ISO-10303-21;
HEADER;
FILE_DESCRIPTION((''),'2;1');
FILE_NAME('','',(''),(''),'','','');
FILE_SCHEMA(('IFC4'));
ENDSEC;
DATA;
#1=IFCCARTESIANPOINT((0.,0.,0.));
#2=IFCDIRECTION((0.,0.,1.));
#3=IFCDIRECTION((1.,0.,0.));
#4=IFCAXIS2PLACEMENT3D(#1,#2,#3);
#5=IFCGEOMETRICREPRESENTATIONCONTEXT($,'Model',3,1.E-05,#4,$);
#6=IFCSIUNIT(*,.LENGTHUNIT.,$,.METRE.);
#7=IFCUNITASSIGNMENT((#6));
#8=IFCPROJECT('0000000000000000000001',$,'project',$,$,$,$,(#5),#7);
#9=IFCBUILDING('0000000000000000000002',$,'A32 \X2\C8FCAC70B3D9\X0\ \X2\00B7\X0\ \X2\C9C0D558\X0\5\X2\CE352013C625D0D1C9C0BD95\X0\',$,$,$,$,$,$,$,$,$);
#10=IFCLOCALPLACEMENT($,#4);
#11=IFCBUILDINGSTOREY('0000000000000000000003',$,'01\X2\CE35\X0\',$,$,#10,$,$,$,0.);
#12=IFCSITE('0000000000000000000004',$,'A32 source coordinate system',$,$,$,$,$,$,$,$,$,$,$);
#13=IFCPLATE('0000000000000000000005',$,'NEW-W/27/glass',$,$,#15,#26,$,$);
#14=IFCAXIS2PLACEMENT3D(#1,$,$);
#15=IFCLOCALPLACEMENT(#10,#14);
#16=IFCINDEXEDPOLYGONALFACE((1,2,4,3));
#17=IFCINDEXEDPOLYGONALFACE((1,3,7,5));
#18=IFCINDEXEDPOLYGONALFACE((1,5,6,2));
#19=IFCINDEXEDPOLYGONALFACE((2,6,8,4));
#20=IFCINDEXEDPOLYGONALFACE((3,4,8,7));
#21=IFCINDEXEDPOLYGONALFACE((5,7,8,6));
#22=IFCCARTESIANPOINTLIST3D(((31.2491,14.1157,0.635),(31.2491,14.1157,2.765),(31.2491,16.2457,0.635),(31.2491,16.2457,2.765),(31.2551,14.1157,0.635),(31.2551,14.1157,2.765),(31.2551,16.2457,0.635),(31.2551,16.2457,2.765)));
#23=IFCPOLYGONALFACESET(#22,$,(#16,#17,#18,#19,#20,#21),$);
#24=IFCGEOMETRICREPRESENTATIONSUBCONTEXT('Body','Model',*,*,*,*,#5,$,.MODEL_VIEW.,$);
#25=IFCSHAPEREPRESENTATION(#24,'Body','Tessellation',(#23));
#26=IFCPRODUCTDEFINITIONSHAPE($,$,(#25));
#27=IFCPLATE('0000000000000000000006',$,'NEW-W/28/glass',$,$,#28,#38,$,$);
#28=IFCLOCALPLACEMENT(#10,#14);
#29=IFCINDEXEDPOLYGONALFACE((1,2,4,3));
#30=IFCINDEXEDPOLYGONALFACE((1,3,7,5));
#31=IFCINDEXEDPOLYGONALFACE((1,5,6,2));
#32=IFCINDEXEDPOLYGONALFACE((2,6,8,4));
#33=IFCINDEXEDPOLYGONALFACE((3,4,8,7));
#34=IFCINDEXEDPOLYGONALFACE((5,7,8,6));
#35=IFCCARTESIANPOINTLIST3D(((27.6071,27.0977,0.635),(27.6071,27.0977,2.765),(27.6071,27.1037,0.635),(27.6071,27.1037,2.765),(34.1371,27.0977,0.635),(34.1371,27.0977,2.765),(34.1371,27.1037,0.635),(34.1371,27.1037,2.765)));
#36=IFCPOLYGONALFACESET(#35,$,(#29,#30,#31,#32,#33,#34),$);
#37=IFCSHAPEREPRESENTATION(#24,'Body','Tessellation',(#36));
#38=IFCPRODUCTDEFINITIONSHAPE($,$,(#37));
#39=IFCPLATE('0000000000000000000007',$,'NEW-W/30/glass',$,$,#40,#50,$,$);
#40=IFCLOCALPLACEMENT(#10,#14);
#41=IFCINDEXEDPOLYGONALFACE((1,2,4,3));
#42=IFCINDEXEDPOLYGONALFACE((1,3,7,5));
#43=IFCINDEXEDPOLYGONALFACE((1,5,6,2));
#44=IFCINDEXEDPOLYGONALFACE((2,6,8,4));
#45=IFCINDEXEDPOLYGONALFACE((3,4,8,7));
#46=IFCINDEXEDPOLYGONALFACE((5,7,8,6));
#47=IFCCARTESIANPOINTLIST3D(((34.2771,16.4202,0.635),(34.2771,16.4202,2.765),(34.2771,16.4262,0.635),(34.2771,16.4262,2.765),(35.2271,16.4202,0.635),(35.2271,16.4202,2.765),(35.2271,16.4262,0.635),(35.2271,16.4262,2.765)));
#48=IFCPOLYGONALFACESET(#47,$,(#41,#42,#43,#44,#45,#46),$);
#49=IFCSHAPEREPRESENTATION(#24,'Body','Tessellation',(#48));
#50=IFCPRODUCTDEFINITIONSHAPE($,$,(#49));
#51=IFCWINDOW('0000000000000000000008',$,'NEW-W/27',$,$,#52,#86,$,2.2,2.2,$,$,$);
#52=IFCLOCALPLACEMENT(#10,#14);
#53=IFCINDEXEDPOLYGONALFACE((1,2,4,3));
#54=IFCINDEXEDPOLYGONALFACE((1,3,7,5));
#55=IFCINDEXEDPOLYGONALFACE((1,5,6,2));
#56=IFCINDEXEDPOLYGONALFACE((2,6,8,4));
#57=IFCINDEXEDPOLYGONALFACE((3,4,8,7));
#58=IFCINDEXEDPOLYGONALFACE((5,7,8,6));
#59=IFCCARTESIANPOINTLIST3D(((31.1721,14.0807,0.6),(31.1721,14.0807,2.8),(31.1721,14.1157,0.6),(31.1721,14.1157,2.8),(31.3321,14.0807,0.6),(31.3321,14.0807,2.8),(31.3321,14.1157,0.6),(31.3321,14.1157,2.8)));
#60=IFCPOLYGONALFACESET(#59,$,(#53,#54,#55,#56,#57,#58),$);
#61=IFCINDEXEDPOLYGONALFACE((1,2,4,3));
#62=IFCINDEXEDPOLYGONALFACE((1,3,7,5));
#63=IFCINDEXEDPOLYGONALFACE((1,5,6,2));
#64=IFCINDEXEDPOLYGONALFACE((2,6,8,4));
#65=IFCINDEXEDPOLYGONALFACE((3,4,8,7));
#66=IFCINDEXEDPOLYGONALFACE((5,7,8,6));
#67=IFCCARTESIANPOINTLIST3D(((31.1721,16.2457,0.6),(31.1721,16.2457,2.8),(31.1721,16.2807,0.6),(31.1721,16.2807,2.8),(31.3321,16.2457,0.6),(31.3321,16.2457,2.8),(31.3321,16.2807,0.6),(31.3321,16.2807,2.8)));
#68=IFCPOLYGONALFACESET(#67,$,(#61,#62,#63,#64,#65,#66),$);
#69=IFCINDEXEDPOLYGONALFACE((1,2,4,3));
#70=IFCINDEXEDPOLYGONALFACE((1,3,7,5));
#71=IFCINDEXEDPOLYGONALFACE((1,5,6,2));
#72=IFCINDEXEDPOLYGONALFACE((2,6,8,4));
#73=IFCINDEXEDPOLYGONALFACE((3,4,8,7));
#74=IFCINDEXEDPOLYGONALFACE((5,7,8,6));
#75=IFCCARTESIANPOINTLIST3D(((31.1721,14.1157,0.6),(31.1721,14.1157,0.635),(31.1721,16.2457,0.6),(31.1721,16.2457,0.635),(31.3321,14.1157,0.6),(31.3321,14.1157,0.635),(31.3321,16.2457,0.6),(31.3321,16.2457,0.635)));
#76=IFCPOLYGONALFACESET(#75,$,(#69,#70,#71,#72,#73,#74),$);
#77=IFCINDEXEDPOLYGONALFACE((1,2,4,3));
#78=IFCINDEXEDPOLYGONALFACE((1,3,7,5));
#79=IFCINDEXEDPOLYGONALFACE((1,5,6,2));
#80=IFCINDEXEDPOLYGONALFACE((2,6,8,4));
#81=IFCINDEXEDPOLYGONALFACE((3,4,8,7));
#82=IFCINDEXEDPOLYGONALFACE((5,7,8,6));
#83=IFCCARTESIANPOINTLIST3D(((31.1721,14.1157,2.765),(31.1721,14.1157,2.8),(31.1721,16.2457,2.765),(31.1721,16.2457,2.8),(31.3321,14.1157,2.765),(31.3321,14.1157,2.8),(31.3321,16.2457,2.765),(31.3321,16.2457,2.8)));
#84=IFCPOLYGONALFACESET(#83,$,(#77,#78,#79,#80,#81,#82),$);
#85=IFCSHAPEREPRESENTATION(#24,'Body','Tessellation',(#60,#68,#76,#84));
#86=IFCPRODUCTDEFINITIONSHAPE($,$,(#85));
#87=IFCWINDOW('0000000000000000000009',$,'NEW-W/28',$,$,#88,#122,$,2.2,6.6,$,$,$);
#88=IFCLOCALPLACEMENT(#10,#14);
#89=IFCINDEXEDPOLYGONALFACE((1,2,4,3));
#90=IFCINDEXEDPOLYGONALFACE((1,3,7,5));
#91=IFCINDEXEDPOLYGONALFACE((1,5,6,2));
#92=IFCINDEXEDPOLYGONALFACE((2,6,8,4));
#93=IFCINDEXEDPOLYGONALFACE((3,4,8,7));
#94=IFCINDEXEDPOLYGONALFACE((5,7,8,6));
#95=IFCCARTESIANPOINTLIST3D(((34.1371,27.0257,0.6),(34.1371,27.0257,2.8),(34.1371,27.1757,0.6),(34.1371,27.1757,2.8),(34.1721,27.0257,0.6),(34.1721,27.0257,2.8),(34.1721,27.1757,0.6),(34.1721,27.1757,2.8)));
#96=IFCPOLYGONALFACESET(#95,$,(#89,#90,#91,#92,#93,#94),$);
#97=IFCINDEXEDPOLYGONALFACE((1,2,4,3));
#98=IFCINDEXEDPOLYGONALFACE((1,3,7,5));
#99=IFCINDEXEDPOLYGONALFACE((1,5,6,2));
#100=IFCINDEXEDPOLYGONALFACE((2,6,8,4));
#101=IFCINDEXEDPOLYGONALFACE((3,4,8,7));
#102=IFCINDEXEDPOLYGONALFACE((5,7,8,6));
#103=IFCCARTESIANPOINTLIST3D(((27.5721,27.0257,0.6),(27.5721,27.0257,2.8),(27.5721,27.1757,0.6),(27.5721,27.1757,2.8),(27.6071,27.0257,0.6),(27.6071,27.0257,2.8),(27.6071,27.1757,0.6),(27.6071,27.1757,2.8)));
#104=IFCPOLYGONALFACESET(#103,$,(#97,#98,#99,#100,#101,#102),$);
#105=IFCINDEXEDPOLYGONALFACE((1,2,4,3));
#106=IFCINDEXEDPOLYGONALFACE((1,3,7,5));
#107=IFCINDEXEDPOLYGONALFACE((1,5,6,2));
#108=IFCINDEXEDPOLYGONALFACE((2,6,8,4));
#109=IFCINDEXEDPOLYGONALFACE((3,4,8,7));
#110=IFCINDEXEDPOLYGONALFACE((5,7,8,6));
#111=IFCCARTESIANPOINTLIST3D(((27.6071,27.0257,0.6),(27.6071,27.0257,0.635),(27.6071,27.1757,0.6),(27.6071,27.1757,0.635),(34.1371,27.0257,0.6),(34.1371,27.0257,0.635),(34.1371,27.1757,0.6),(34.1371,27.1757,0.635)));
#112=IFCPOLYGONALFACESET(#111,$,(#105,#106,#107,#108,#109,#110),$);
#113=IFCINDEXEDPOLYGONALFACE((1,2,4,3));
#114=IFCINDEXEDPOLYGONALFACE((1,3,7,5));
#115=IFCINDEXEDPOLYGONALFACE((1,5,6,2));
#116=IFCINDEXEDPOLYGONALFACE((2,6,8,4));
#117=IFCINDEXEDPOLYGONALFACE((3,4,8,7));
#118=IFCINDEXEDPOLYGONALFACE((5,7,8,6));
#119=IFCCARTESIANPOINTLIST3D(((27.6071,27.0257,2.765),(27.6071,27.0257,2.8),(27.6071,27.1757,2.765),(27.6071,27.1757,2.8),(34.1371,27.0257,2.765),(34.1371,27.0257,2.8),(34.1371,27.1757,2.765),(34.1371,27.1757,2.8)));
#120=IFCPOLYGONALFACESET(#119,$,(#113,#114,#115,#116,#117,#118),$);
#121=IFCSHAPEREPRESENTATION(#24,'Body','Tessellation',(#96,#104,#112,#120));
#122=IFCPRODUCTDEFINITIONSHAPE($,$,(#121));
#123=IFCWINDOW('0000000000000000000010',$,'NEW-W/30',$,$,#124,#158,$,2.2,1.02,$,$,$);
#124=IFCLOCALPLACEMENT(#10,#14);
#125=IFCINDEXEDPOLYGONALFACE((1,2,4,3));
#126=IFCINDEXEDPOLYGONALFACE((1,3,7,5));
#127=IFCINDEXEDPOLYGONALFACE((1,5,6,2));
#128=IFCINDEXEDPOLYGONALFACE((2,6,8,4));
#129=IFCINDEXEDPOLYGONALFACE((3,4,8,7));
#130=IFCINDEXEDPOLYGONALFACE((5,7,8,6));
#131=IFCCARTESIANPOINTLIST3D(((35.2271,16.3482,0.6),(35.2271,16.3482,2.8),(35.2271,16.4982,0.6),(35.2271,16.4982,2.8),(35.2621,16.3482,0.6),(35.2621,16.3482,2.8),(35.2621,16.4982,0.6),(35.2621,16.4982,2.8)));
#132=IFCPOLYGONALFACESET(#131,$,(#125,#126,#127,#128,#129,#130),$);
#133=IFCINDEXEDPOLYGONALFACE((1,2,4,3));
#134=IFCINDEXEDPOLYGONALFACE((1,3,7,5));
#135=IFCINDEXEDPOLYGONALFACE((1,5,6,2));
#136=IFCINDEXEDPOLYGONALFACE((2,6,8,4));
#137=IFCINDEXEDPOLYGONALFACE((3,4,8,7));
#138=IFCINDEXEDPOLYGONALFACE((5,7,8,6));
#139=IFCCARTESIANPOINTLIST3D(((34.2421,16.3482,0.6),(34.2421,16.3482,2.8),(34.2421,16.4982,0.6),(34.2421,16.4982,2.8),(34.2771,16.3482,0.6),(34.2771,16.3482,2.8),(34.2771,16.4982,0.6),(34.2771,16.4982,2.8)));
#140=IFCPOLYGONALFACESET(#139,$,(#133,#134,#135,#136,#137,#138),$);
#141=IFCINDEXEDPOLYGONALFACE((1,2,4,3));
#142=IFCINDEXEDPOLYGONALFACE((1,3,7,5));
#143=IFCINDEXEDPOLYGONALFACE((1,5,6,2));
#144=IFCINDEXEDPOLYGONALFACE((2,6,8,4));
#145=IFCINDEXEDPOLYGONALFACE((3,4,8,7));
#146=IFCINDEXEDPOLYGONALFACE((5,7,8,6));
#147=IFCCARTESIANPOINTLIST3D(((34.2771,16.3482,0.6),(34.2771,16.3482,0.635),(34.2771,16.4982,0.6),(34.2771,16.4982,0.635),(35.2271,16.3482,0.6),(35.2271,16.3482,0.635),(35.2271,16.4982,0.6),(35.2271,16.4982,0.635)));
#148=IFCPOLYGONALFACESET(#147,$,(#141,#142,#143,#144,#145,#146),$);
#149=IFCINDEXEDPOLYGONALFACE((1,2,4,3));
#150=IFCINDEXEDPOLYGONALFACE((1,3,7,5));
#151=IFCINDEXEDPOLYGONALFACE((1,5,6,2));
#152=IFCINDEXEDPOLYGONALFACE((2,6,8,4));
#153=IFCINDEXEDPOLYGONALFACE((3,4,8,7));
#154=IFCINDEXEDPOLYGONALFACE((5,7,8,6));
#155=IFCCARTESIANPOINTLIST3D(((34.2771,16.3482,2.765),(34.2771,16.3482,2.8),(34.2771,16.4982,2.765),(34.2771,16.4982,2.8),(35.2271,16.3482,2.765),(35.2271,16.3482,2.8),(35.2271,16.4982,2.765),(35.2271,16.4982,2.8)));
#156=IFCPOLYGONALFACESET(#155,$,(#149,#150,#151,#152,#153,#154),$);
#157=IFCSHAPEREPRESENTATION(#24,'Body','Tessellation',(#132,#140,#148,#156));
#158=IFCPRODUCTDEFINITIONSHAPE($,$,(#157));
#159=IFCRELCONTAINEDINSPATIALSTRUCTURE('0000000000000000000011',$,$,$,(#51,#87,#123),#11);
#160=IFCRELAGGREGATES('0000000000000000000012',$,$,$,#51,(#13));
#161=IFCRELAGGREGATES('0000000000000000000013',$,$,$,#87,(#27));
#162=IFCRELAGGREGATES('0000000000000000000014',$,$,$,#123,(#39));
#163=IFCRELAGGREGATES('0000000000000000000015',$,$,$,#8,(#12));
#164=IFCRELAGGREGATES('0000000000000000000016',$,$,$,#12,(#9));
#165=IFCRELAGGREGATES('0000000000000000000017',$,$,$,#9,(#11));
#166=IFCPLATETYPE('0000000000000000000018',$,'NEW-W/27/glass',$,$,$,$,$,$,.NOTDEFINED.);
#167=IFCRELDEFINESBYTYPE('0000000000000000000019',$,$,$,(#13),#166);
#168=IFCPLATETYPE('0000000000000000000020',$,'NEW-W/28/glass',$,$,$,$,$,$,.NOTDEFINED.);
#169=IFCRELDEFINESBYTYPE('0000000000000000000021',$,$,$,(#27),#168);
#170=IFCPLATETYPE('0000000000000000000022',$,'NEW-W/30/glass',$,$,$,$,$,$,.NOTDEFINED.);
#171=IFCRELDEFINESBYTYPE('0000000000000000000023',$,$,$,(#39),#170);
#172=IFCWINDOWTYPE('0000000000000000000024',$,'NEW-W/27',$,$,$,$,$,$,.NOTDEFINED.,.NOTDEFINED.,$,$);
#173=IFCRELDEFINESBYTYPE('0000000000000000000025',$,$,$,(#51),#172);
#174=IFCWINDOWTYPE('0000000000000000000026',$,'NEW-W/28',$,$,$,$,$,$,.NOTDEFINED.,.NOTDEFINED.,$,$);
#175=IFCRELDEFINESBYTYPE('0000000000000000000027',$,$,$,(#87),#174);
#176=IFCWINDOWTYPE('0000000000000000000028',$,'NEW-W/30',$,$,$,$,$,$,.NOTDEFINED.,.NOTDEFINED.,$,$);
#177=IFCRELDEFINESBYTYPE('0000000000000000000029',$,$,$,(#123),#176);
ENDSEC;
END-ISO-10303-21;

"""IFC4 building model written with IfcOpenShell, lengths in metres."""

from ifc_helpers import new_model, si_unit, frame, origin, origin_with_axes, place, context, subcontext, project, spatial, polyline, outline, extrude, source, transform, mapped, type_object, type_shapes, element, aggregate, save


model = new_model("IFC4")

# Units and contexts
model_context = context("Model", 3, precision=1e-05, world=origin_with_axes())
body_context = subcontext(model_context, "Body", "Model", "MODEL_VIEW")
ifc_project = project(units=[si_unit("LENGTHUNIT", "METRE")], contexts=[model_context])

# Plates
storey_placement = place(None, origin_with_axes())
plate_type_1 = type_object("IfcPlateType", Name="NEW-W/27/glass", PredefinedType="NOTDEFINED")
shared_shape_1 = source(origin(), body_context, "Body", "SweptSolid", [
    extrude(outline(polyline([(31.2551, 14.1157), (31.2491, 14.1157), (31.2491, 16.2457), (31.2551, 16.2457), (31.2551, 14.1157)])), frame((0.0, 0.0, 0.635)), (0.0, 0.0, 1.0), 2.13),
])
type_shapes(plate_type_1, [shared_shape_1])
window_1_placement = place(storey_placement, origin_with_axes())
plate_1_placement = place(window_1_placement, origin_with_axes())
plate_1 = element("IfcPlate", 1, at=plate_1_placement, type_object=plate_type_1, Name="NEW-W/27/glass", context=body_context, shape_type="MappedRepresentation", body=[
    mapped(shared_shape_1, transform((0.0, 0.0, 0.0), scale=1.0)),
])
plate_type_2 = type_object("IfcPlateType", Name="NEW-W/28/glass", PredefinedType="NOTDEFINED")
shared_shape_2 = source(origin(), body_context, "Body", "SweptSolid", [
    extrude(outline(polyline([(34.1371, 27.0977), (27.6071, 27.0977), (27.6071, 27.1037), (34.1371, 27.1037), (34.1371, 27.0977)])), frame((0.0, 0.0, 0.635)), (0.0, 0.0, 1.0), 2.13),
])
type_shapes(plate_type_2, [shared_shape_2])
window_2_placement = place(storey_placement, origin_with_axes())
plate_2_placement = place(window_2_placement, origin_with_axes())
plate_2 = element("IfcPlate", 2, at=plate_2_placement, type_object=plate_type_2, Name="NEW-W/28/glass", context=body_context, shape_type="MappedRepresentation", body=[
    mapped(shared_shape_2, transform((0.0, 0.0, 0.0), scale=1.0)),
])
plate_type_3 = type_object("IfcPlateType", Name="NEW-W/30/glass", PredefinedType="NOTDEFINED")
shared_shape_3 = source(origin(), body_context, "Body", "SweptSolid", [
    extrude(outline(polyline([(35.2271, 16.4202), (34.2771, 16.4202), (34.2771, 16.4262), (35.2271, 16.4262), (35.2271, 16.4202)])), frame((0.0, 0.0, 0.635)), (0.0, 0.0, 1.0), 2.13),
])
type_shapes(plate_type_3, [shared_shape_3])
window_3_placement = place(storey_placement, origin_with_axes())
plate_3_placement = place(window_3_placement, origin_with_axes())
plate_3 = element("IfcPlate", 3, at=plate_3_placement, type_object=plate_type_3, Name="NEW-W/30/glass", context=body_context, shape_type="MappedRepresentation", body=[
    mapped(shared_shape_3, transform((0.0, 0.0, 0.0), scale=1.0)),
])

# Site, building, storey
site = spatial("IfcSite", under=ifc_project, Name="A32 source coordinate system")
building = spatial("IfcBuilding", under=site, Name="A32 주거동 · 지하5층–옥탑지붕")
storey = spatial("IfcBuildingStorey", under=building, at=storey_placement, Name="01층", Elevation=0.0)

# Windows
window_type_1 = type_object("IfcWindowType", Name="NEW-W/27", PartitioningType="NOTDEFINED", PredefinedType="NOTDEFINED")
shared_shape_4 = source(origin(), body_context, "Body", "SweptSolid", [
    extrude(outline(polyline([(31.1721, 14.0807), (31.1721, 14.1157), (31.3321, 14.1157), (31.3321, 14.0807), (31.1721, 14.0807)])), frame((0.0, 0.0, 0.6)), (0.0, 0.0, 1.0), 2.2),
    extrude(outline(polyline([(31.1721, 16.2457), (31.1721, 16.2807), (31.3321, 16.2807), (31.3321, 16.2457), (31.1721, 16.2457)])), frame((0.0, 0.0, 0.6)), (0.0, 0.0, 1.0), 2.2),
    extrude(outline(polyline([(31.3321, 14.1157), (31.3321, 16.2457), (31.1721, 16.2457), (31.1721, 14.1157), (31.3321, 14.1157)])), frame((0.0, 0.0, 0.6)), (0.0, 0.0, 1.0), 0.035),
    extrude(outline(polyline([(31.3321, 14.1157), (31.3321, 16.2457), (31.1721, 16.2457), (31.1721, 14.1157), (31.3321, 14.1157)])), frame((0.0, 0.0, 2.765)), (0.0, 0.0, 1.0), 0.035),
])
type_shapes(window_type_1, [shared_shape_4])
window_1 = element("IfcWindow", 4, at=window_1_placement, inside=storey, type_object=window_type_1, Name="NEW-W/27", OverallHeight=2.2, OverallWidth=2.2, context=body_context, shape_type="MappedRepresentation", body=[
    mapped(shared_shape_4, transform((0.0, 0.0, 0.0), scale=1.0)),
])
aggregate(window_1, [plate_1])
window_type_2 = type_object("IfcWindowType", Name="NEW-W/28", PartitioningType="NOTDEFINED", PredefinedType="NOTDEFINED")
shared_shape_5 = source(origin(), body_context, "Body", "SweptSolid", [
    extrude(outline(polyline([(34.1371, 27.0257), (34.1371, 27.1757), (34.1721, 27.1757), (34.1721, 27.0257), (34.1371, 27.0257)])), frame((0.0, 0.0, 0.6)), (0.0, 0.0, 1.0), 2.2),
    extrude(outline(polyline([(27.5721, 27.0257), (27.5721, 27.1757), (27.6071, 27.1757), (27.6071, 27.0257), (27.5721, 27.0257)])), frame((0.0, 0.0, 0.6)), (0.0, 0.0, 1.0), 2.2),
    extrude(outline(polyline([(34.1371, 27.0257), (34.1371, 27.1757), (27.6071, 27.1757), (27.6071, 27.0257), (34.1371, 27.0257)])), frame((0.0, 0.0, 0.6)), (0.0, 0.0, 1.0), 0.035),
    extrude(outline(polyline([(34.1371, 27.0257), (34.1371, 27.1757), (27.6071, 27.1757), (27.6071, 27.0257), (34.1371, 27.0257)])), frame((0.0, 0.0, 2.765)), (0.0, 0.0, 1.0), 0.035),
])
type_shapes(window_type_2, [shared_shape_5])
window_2 = element("IfcWindow", 5, at=window_2_placement, inside=storey, type_object=window_type_2, Name="NEW-W/28", OverallHeight=2.2, OverallWidth=6.6, context=body_context, shape_type="MappedRepresentation", body=[
    mapped(shared_shape_5, transform((0.0, 0.0, 0.0), scale=1.0)),
])
aggregate(window_2, [plate_2])
window_type_3 = type_object("IfcWindowType", Name="NEW-W/30", PartitioningType="NOTDEFINED", PredefinedType="NOTDEFINED")
shared_shape_6 = source(origin(), body_context, "Body", "SweptSolid", [
    extrude(outline(polyline([(35.2271, 16.3482), (35.2271, 16.4982), (35.2621, 16.4982), (35.2621, 16.3482), (35.2271, 16.3482)])), frame((0.0, 0.0, 0.6)), (0.0, 0.0, 1.0), 2.2),
    extrude(outline(polyline([(34.2421, 16.3482), (34.2421, 16.4982), (34.2771, 16.4982), (34.2771, 16.3482), (34.2421, 16.3482)])), frame((0.0, 0.0, 0.6)), (0.0, 0.0, 1.0), 2.2),
    extrude(outline(polyline([(35.2271, 16.3482), (35.2271, 16.4982), (34.2771, 16.4982), (34.2771, 16.3482), (35.2271, 16.3482)])), frame((0.0, 0.0, 0.6)), (0.0, 0.0, 1.0), 0.035),
    extrude(outline(polyline([(35.2271, 16.3482), (35.2271, 16.4982), (34.2771, 16.4982), (34.2771, 16.3482), (35.2271, 16.3482)])), frame((0.0, 0.0, 2.765)), (0.0, 0.0, 1.0), 0.035),
])
type_shapes(window_type_3, [shared_shape_6])
window_3 = element("IfcWindow", 6, at=window_3_placement, inside=storey, type_object=window_type_3, Name="NEW-W/30", OverallHeight=2.2, OverallWidth=1.02, context=body_context, shape_type="MappedRepresentation", body=[
    mapped(shared_shape_6, transform((0.0, 0.0, 0.0), scale=1.0)),
])
aggregate(window_3, [plate_3])

save(model, "model.ifc")
